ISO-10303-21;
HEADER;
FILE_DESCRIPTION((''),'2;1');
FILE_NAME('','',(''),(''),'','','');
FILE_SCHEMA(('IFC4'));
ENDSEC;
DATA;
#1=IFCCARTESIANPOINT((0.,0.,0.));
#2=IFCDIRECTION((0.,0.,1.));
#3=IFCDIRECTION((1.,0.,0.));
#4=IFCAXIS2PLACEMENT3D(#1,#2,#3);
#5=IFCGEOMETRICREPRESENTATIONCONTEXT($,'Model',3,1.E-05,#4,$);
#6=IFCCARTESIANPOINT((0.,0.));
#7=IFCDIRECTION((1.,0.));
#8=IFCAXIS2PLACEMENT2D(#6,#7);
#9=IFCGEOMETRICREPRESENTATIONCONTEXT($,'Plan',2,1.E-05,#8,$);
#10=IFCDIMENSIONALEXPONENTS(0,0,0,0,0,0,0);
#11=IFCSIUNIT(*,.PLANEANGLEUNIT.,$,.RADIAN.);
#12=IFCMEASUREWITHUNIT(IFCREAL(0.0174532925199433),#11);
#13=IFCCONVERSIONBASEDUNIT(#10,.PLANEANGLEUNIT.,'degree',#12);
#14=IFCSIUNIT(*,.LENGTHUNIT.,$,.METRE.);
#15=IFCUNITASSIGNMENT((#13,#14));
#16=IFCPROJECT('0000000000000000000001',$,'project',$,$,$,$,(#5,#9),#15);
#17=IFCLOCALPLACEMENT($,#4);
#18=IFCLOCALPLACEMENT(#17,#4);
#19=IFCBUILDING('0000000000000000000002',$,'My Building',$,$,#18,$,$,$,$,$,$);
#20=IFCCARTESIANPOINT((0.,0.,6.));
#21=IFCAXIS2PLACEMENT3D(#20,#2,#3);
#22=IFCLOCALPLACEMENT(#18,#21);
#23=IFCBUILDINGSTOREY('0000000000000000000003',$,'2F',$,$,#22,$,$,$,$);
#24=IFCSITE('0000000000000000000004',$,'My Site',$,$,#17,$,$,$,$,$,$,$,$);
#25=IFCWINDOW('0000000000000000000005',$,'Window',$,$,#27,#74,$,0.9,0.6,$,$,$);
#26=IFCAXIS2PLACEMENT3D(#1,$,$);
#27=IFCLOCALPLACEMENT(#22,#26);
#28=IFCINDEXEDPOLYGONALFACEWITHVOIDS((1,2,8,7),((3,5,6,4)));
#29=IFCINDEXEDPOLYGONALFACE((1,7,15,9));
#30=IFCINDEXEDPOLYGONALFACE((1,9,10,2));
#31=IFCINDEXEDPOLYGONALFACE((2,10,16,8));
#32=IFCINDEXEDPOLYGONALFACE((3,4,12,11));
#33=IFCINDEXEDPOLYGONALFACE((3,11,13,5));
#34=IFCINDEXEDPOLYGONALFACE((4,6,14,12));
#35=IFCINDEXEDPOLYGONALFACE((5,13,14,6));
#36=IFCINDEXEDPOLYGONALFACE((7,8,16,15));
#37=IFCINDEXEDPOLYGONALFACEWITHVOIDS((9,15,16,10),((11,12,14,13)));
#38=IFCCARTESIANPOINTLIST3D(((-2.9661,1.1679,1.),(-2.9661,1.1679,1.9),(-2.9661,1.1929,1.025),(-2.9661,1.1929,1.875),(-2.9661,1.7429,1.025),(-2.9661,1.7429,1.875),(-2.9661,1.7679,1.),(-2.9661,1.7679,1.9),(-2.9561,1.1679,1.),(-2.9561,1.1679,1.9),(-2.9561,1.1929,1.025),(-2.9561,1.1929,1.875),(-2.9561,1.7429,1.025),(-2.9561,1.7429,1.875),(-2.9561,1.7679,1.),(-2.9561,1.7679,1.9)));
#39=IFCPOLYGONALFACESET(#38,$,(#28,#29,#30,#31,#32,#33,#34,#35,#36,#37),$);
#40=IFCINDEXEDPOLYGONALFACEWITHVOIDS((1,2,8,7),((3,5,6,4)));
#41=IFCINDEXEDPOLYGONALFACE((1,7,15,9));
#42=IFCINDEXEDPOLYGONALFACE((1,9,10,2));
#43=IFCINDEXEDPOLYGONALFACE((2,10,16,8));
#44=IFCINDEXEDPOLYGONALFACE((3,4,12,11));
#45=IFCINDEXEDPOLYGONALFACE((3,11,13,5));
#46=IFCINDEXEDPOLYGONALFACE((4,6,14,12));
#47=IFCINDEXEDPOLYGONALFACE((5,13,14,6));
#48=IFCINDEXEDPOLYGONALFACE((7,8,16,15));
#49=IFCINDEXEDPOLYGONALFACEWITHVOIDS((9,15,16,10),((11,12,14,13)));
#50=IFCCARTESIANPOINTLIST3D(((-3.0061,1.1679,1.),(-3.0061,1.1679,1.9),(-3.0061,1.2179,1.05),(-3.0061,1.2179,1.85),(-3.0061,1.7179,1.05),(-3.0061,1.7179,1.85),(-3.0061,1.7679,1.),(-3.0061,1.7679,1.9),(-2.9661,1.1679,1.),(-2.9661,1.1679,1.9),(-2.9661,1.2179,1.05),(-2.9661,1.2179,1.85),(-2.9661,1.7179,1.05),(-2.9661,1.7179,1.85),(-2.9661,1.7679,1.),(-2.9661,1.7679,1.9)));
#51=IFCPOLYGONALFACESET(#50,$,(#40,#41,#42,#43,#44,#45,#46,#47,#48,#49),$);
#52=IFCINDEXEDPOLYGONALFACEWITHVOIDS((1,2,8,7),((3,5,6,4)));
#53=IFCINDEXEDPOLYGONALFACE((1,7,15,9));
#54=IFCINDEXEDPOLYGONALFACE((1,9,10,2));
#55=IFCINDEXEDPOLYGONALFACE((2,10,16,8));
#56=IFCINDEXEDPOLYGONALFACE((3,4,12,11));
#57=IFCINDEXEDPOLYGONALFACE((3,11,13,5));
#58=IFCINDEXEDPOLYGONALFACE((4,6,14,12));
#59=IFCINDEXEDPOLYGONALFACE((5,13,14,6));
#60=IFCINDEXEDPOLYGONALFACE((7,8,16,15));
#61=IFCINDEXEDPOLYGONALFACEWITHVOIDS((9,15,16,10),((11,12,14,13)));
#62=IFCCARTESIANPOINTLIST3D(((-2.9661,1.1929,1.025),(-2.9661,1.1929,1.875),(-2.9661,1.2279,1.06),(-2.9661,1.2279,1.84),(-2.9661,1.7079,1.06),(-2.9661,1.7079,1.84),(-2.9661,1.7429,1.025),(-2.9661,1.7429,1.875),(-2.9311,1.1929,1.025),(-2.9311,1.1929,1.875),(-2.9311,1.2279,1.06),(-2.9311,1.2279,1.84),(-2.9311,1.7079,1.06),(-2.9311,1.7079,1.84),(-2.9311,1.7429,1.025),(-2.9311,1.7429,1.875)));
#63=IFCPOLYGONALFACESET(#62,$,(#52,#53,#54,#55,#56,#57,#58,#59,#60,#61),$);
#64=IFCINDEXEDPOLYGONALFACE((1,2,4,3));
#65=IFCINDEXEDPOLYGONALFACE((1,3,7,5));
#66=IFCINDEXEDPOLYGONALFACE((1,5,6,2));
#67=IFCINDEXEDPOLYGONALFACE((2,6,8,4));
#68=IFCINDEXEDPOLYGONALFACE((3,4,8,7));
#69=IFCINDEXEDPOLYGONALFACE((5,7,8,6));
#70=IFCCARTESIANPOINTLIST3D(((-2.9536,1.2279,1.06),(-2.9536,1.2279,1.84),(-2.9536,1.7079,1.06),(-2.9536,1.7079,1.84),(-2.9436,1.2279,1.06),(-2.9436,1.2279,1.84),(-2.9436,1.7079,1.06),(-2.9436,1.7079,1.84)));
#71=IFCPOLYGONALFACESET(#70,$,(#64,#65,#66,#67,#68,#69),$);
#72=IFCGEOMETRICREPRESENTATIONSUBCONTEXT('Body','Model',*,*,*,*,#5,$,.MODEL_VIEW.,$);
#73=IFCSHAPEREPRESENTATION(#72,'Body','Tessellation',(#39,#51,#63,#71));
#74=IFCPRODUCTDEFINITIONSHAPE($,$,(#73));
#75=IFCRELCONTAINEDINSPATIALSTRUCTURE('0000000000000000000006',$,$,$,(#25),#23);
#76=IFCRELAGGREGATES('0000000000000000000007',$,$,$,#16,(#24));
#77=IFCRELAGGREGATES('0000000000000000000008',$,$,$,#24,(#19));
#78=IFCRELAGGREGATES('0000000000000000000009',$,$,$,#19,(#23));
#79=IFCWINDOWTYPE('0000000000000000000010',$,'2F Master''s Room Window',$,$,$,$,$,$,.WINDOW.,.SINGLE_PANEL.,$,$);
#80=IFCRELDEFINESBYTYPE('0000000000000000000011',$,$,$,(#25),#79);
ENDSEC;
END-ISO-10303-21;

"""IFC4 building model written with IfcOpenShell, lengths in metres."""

from ifc_helpers import new_model, entity, si_unit, converted_unit, frame, origin_with_axes, origin_2d_with_axis, place, context, subcontext, project, spatial, line, indexed_curve, outline, extrude, shape, source, transform, mapped, type_object, type_shapes, element, save


model = new_model("IFC4")

# Units and contexts
model_context = context("Model", 3, precision=1e-05, world=origin_with_axes())
plan_context = context("Plan", 2, precision=1e-05, world=origin_2d_with_axis())
body_context_1 = subcontext(model_context, "Body", "Model", "MODEL_VIEW")
body_context_2 = subcontext(plan_context, "Body", "Plan", "PLAN_VIEW")
ifc_project = project(units=[converted_unit("PLANEANGLEUNIT", "degree", entity("IfcReal", 0.0174532925199433), si_unit("PLANEANGLEUNIT", "RADIAN"), dimensions=[0, 0, 0, 0, 0, 0, 0]), si_unit("LENGTHUNIT", "METRE")], contexts=[model_context, plan_context])

# Site, building, storey
site_placement = place(None, origin_with_axes())
site = spatial("IfcSite", under=ifc_project, at=site_placement, Name="My Site")
building_placement = place(site_placement, origin_with_axes())
building = spatial("IfcBuilding", under=site, at=building_placement, Name="My Building")
storey_placement = place(building_placement, frame((0.0, 0.0, 6.0), z_axis=(0.0, 0.0, 1.0), x_axis=(1.0, 0.0, 0.0)))
storey = spatial("IfcBuildingStorey", under=building, at=storey_placement, Name="2F")

# Window
window_type_1 = type_object("IfcWindowType", Name="2F Master's Room Window", PartitioningType="SINGLE_PANEL", PredefinedType="WINDOW")
shared_shape_1 = source(origin_with_axes(), body_context_1, "Body", "SweptSolid", [
    extrude(outline(indexed_curve([(0.0, 0.0), (0.6, 0.0), (0.6, 0.9), (0.0, 0.9)], segments=[line(1, 2, 3, 4, 1)]), holes=[indexed_curve([(0.025, 0.025), (0.575, 0.025), (0.575, 0.875), (0.025, 0.875)], segments=[line(1, 2, 3, 4, 1)])]), frame((0.0, 0.09, 0.0), z_axis=(0.0, -1.0, 0.0), x_axis=(1.0, 0.0, 0.0)), (0.0, 0.0, -1.0), 0.01),
    extrude(outline(indexed_curve([(0.0, 0.0), (0.6, 0.0), (0.6, 0.9), (0.0, 0.9)], segments=[line(1, 2, 3, 4, 1)]), holes=[indexed_curve([(0.05, 0.05), (0.55, 0.05), (0.55, 0.85), (0.05, 0.85)], segments=[line(1, 2, 3, 4, 1)])]), frame((0.0, 0.05, 0.0), z_axis=(0.0, -1.0, 0.0), x_axis=(1.0, 0.0, 0.0)), (0.0, 0.0, -1.0), 0.04),
    extrude(outline(indexed_curve([(0.0, 0.0), (0.55, 0.0), (0.55, 0.85), (0.0, 0.85)], segments=[line(1, 2, 3, 4, 1)]), holes=[indexed_curve([(0.035, 0.035), (0.515, 0.035), (0.515, 0.815), (0.035, 0.815)], segments=[line(1, 2, 3, 4, 1)])]), frame((0.025, 0.09, 0.025), z_axis=(0.0, -1.0, 0.0), x_axis=(1.0, 0.0, 0.0)), (0.0, 0.0, -1.0), 0.035),
    extrude(outline(indexed_curve([(0.035, 0.035), (0.515, 0.035), (0.515, 0.815), (0.035, 0.815)], segments=[line(1, 2, 3, 4, 1)])), frame((0.025, 0.1025, 0.025), z_axis=(0.0, -1.0, 0.0), x_axis=(1.0, 0.0, 0.0)), (0.0, 0.0, -1.0), 0.01),
])
shared_shape_2 = source(origin_with_axes(), body_context_2, "Body", "Curve2D", [
    entity("IfcIndexedPolyCurve", entity("IfcCartesianPointList2D", [[0.05, 0.05], [0.55, 0.05]])),
    entity("IfcIndexedPolyCurve", entity("IfcCartesianPointList2D", [[0.0, 0.1], [0.025, 0.1], [0.025, 0.09], [0.05, 0.09], [0.05, 0.05], [0.0, 0.05]]), [entity("IfcLineIndex", [1, 2, 3, 4, 5, 6, 1])]),
    entity("IfcIndexedPolyCurve", entity("IfcCartesianPointList2D", [[0.6, 0.1], [0.575, 0.1], [0.575, 0.09], [0.55, 0.09], [0.55, 0.05], [0.6, 0.05]]), [entity("IfcLineIndex", [1, 2, 3, 4, 5, 6, 1])]),
    entity("IfcIndexedPolyCurve", entity("IfcCartesianPointList2D", [[0.025, 0.09], [0.06, 0.09], [0.06, 0.125], [0.025, 0.125]]), [entity("IfcLineIndex", [1, 2, 3, 4, 1])]),
    entity("IfcIndexedPolyCurve", entity("IfcCartesianPointList2D", [[0.575, 0.09], [0.54, 0.09], [0.54, 0.125], [0.575, 0.125]]), [entity("IfcLineIndex", [1, 2, 3, 4, 1])]),
    entity("IfcIndexedPolyCurve", entity("IfcCartesianPointList2D", [[0.06, 0.09], [0.54, 0.09]])),
    entity("IfcIndexedPolyCurve", entity("IfcCartesianPointList2D", [[0.06, 0.125], [0.54, 0.125]])),
    entity("IfcIndexedPolyCurve", entity("IfcCartesianPointList2D", [[0.06, 0.1075], [0.54, 0.1075]])),
])
type_shapes(window_type_1, [shared_shape_1, shared_shape_2])
placement_1 = place(storey_placement, frame((-3.0561, 5.4041, 0.0), z_axis=(0.0, 0.0, 1.0), x_axis=(0.0, -1.0, 0.0)))
placement_2 = place(placement_1, frame((3.6362, 0.0, 1.0), z_axis=(0.0, 0.0, 1.0), x_axis=(1.0, 0.0, 0.0)))
window_1_placement = place(placement_2, frame((0.0, 0.0, 0.0), z_axis=(0.0, 0.0, 1.0), x_axis=(1.0, 0.0, 0.0)))
element("IfcWindow", 1, at=window_1_placement, inside=storey, type_object=window_type_1, Name="Window", OverallHeight=0.9, OverallWidth=0.6, shapes=[
    shape(body_context_1, "Body", "MappedRepresentation", [mapped(shared_shape_1, transform((0.0, 0.0, 0.0), x_axis=(1.0, 0.0, 0.0), y_axis=(0.0, 1.0, 0.0), z_axis=(0.0, 0.0, 1.0), scale=1.0))]),
    shape(body_context_2, "Body", "MappedRepresentation", [mapped(shared_shape_2, transform((0.0, 0.0, 0.0), x_axis=(1.0, 0.0, 0.0), y_axis=(0.0, 1.0, 0.0), z_axis=(0.0, 0.0, 1.0), scale=1.0))]),
])

save(model, "model.ifc")
